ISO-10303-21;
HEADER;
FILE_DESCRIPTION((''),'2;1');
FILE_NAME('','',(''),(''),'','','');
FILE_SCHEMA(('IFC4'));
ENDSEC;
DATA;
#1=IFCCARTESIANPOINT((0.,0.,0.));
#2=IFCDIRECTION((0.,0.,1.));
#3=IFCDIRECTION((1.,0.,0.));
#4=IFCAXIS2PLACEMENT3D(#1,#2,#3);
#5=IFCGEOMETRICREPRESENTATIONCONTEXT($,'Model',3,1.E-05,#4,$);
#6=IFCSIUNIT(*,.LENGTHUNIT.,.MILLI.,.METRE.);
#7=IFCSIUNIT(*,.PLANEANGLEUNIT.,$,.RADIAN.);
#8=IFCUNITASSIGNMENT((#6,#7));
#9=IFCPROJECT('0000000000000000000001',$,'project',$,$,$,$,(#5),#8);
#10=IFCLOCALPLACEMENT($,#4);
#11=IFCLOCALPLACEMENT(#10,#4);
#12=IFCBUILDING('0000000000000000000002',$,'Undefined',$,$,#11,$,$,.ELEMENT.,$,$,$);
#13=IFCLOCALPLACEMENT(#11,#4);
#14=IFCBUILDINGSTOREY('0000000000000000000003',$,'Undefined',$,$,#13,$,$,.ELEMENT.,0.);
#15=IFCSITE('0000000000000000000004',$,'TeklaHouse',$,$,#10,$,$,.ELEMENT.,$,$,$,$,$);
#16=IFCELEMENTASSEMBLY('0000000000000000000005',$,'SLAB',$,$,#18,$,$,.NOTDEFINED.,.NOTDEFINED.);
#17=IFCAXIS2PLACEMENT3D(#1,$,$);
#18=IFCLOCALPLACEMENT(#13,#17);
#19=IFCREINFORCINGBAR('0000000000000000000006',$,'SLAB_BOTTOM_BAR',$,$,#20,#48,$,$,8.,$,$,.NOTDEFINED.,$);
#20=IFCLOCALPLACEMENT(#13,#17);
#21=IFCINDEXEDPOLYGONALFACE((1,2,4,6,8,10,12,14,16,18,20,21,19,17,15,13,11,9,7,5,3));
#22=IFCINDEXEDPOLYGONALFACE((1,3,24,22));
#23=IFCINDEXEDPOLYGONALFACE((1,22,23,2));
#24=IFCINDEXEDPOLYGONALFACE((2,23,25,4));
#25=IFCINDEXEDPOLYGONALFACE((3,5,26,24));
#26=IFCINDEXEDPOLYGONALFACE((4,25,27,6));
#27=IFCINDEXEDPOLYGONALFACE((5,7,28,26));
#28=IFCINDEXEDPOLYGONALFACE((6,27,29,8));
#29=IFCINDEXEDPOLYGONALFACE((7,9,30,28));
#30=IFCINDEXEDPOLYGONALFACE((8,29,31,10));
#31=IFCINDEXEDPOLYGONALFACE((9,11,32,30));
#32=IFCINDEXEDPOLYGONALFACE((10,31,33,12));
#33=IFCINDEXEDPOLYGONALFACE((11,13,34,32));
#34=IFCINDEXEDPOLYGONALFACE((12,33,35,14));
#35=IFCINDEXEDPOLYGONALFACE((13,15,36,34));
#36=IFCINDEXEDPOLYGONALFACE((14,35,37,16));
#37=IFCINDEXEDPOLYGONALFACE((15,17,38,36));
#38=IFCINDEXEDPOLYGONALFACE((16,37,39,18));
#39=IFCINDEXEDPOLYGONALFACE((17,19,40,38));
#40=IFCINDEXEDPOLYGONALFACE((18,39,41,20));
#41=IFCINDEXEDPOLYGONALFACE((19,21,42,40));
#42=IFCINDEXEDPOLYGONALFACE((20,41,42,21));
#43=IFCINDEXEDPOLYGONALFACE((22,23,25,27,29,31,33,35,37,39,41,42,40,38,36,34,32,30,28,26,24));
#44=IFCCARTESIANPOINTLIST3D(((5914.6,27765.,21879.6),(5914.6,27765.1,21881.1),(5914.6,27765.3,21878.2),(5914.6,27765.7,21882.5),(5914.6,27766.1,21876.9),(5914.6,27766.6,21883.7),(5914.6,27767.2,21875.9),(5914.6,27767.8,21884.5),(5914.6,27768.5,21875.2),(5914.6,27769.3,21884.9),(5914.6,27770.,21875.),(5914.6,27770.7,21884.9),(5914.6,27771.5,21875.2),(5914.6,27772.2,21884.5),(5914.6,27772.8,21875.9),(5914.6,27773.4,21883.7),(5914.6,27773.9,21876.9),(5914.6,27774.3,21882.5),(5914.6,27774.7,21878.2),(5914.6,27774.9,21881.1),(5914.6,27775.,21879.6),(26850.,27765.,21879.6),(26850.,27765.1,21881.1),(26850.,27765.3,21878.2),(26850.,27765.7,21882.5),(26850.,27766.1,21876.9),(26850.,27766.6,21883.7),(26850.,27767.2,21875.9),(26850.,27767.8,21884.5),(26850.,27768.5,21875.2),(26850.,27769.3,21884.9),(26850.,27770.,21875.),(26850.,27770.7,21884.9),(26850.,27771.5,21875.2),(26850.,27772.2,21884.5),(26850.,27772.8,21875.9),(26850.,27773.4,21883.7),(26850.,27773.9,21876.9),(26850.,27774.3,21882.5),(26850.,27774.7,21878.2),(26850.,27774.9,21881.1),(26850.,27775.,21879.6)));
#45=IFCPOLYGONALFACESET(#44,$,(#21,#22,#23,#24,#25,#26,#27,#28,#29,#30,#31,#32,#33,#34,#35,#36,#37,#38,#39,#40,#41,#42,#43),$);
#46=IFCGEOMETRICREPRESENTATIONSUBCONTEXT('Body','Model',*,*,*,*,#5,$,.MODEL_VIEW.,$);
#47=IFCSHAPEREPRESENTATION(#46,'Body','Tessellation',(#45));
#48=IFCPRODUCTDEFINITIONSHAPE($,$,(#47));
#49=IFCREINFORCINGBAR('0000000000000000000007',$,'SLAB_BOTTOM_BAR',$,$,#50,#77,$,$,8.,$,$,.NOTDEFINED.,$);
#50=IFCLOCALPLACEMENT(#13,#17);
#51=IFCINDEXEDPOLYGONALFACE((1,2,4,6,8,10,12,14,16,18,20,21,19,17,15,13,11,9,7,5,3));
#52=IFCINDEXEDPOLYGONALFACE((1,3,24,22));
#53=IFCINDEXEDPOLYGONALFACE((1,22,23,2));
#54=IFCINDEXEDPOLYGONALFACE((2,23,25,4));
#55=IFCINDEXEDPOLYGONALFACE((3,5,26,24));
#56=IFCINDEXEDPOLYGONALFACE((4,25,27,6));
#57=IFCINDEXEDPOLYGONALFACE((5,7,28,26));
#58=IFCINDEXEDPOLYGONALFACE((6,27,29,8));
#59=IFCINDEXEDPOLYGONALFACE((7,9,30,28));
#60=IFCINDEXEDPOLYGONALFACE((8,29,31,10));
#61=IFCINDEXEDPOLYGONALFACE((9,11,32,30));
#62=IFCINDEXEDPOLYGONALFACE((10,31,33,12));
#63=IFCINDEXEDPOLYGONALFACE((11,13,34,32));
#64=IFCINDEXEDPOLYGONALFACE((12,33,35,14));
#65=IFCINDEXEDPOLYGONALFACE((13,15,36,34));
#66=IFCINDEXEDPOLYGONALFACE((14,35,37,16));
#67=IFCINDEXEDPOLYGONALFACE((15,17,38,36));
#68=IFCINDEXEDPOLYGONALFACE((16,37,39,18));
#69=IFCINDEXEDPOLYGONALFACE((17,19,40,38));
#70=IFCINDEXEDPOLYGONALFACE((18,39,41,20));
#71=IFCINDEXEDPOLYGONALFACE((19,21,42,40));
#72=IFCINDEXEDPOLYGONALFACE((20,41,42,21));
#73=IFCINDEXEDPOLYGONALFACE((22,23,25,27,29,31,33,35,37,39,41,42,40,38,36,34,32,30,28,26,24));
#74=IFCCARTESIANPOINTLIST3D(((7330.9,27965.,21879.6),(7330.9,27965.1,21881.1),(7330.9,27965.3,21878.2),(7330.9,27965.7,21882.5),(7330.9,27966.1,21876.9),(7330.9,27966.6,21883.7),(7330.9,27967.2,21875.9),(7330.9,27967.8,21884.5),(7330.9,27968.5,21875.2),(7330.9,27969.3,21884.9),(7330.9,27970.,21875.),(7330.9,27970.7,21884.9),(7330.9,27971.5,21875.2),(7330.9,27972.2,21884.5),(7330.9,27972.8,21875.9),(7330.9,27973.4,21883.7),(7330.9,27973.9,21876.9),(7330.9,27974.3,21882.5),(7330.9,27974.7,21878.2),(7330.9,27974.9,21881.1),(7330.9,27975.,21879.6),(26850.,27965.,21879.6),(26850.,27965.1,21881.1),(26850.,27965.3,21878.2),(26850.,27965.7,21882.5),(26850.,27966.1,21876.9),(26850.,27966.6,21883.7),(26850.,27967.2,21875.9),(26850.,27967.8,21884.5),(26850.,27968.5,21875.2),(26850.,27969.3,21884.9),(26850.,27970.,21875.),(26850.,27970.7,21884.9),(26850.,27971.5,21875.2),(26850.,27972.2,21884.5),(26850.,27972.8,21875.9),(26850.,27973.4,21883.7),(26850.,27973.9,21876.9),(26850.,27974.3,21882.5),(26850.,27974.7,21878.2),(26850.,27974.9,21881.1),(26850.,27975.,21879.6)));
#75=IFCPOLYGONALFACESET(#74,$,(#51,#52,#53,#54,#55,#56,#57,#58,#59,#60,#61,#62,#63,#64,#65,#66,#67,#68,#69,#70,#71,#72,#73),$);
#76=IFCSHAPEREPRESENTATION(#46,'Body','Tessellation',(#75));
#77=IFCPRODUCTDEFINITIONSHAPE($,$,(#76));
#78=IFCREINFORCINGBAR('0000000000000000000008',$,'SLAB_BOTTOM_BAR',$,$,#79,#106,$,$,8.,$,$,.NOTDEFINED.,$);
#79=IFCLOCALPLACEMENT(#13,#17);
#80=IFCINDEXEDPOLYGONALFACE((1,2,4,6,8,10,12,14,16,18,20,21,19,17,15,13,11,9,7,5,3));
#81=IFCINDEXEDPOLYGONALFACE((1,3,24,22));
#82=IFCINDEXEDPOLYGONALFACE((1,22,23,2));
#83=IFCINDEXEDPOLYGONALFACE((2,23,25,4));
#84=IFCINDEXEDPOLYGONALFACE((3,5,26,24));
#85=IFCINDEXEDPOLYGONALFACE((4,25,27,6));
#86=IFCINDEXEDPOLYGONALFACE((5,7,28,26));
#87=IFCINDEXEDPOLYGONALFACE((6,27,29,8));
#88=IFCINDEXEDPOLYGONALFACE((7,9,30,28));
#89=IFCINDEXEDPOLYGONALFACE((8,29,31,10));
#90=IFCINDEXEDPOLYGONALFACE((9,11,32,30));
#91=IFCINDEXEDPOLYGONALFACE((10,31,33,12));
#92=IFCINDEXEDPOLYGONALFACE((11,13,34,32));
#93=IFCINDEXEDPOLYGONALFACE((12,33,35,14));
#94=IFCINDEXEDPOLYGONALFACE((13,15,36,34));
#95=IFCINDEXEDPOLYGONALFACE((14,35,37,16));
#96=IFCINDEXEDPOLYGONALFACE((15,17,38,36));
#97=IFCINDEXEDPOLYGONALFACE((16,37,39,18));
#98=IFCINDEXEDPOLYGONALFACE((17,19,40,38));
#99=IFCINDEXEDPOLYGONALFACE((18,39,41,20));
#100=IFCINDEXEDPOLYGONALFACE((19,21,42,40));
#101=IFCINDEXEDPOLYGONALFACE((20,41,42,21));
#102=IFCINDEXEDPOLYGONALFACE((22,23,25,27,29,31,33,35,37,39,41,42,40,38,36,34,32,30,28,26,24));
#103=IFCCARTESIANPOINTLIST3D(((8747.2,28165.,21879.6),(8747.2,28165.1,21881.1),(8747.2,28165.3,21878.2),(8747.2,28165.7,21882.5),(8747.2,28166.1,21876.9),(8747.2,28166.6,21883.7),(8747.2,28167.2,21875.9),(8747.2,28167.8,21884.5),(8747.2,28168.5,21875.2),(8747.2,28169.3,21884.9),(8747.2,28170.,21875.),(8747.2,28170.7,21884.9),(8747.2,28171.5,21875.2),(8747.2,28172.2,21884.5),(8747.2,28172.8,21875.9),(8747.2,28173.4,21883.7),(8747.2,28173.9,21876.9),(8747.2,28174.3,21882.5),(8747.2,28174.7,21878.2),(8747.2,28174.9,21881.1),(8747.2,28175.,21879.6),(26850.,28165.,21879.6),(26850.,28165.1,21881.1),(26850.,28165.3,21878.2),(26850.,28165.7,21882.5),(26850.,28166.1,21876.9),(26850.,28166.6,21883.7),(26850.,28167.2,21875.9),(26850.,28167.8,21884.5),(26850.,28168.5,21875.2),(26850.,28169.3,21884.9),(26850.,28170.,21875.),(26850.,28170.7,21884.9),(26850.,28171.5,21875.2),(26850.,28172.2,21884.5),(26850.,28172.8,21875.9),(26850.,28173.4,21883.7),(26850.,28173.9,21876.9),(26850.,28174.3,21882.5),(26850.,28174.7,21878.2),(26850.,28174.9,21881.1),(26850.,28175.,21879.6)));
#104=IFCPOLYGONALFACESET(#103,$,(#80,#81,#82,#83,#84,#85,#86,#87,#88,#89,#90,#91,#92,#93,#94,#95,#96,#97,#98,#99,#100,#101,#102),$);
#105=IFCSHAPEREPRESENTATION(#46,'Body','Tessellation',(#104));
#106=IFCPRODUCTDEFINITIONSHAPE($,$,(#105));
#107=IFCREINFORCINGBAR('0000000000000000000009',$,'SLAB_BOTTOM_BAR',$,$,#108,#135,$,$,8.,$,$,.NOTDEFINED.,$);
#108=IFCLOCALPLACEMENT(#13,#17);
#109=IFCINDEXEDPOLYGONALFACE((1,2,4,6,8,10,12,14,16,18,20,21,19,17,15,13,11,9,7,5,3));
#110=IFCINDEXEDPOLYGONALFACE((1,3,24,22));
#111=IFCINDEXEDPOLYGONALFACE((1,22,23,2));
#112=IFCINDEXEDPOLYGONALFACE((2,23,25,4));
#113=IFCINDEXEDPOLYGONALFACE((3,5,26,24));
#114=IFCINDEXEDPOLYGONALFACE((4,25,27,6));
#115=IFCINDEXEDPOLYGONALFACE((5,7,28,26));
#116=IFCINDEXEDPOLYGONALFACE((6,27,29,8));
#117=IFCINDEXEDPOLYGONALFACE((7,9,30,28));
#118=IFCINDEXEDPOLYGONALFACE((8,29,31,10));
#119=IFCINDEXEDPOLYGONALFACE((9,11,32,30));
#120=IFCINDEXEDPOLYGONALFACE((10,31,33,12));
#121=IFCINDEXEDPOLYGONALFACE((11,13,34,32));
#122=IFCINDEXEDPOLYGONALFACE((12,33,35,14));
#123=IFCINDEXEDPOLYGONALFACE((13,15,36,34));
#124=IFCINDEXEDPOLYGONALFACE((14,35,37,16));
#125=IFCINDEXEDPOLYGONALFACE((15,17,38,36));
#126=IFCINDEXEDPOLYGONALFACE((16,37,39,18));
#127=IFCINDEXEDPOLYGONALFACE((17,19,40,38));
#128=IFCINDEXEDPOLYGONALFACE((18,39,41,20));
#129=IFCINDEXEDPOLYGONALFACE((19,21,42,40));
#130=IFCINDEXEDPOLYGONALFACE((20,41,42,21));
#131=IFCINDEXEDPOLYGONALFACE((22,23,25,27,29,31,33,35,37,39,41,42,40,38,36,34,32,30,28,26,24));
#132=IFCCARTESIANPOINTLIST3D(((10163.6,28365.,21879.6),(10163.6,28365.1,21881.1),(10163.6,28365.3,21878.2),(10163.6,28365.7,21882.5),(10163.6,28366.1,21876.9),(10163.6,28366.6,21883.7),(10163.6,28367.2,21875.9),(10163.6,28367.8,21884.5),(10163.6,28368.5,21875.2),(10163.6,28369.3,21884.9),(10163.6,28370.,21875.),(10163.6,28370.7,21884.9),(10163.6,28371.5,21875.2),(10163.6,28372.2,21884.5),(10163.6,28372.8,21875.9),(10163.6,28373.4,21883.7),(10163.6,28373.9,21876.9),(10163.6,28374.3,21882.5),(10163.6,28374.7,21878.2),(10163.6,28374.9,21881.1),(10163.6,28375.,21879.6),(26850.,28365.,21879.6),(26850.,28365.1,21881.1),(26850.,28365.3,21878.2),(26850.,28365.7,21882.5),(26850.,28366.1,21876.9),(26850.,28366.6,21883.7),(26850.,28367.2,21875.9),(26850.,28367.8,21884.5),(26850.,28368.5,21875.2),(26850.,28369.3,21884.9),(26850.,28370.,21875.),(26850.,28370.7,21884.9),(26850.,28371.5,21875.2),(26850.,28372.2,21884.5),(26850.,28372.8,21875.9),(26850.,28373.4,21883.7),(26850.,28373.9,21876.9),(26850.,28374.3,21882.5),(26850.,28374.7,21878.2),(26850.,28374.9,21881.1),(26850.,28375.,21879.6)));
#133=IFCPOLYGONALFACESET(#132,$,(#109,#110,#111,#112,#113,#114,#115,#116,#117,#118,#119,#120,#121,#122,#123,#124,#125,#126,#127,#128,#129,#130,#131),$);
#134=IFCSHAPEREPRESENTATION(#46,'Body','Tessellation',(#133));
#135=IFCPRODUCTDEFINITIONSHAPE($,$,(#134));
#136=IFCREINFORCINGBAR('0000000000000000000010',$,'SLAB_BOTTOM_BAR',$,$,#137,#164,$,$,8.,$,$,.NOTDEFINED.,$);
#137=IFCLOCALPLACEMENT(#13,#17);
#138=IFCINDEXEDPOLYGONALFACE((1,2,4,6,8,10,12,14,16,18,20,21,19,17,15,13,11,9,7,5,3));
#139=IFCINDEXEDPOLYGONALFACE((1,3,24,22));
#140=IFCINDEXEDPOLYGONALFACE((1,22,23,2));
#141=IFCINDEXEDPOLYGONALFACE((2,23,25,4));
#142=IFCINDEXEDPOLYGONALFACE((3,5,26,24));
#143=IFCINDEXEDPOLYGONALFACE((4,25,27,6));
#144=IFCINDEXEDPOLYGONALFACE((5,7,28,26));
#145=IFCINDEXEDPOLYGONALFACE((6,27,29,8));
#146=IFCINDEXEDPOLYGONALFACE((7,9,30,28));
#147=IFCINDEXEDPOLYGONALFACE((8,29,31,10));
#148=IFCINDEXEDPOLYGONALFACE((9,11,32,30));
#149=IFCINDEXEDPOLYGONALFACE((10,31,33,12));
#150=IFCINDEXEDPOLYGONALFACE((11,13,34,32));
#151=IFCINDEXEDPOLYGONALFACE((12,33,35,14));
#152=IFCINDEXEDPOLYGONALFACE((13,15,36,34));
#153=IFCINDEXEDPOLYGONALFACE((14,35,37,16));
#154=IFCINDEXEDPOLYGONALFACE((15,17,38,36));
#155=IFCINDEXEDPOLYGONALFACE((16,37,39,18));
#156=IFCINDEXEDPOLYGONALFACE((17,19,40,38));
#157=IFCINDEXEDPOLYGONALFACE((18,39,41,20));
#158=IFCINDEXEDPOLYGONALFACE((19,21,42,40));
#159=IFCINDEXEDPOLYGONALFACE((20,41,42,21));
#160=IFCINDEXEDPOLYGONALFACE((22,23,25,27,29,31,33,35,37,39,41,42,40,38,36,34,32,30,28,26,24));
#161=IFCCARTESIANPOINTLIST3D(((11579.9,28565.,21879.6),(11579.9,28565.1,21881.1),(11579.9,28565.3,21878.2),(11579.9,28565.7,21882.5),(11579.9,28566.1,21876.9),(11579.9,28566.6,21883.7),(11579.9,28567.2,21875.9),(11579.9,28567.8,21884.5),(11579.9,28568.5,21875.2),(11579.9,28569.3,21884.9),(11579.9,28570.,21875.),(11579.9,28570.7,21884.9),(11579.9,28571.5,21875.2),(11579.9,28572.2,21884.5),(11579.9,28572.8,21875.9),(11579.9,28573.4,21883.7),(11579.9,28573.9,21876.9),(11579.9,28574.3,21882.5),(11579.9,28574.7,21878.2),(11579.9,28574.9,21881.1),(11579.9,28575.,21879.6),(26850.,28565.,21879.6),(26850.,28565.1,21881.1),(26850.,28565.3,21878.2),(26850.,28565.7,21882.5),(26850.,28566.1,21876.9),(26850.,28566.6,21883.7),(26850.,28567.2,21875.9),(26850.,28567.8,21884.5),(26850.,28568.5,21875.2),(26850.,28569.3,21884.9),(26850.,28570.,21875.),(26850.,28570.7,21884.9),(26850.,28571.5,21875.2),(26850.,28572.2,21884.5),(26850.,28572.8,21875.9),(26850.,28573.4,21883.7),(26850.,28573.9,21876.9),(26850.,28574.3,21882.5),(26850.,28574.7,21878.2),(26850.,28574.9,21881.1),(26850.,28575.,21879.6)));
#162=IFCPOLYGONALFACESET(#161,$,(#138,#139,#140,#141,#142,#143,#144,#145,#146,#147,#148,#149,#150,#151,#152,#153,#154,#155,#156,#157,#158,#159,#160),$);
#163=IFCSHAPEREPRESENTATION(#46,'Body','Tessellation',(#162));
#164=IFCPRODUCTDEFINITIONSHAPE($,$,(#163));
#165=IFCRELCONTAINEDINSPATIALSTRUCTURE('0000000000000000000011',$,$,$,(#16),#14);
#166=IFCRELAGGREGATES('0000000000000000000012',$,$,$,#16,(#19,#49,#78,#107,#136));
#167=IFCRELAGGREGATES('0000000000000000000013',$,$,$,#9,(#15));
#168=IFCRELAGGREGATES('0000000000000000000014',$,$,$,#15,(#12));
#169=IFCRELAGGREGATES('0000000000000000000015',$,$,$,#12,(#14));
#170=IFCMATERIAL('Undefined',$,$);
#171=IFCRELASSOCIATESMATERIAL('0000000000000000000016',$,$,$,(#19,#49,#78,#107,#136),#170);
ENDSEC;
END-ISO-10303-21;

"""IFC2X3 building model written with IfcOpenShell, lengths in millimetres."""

from ifc_helpers import new_model, entity, si_unit, frame, origin_with_axes, place, context, subcontext, project, spatial, source, transform, mapped, material, element, aggregate, save


model = new_model("IFC2X3")

# Units and contexts
model_context = context("Model", 3, precision=1e-05, world=origin_with_axes())
body_context = subcontext(model_context, "Body", "Model", "MODEL_VIEW")
ifc_project = project(units=[si_unit("LENGTHUNIT", "METRE", prefix="MILLI"), si_unit("PLANEANGLEUNIT", "RADIAN")], contexts=[model_context])

# Site, building, storey
site_placement = place(None, origin_with_axes())
site = spatial("IfcSite", under=ifc_project, at=site_placement, Name="TeklaHouse", CompositionType="ELEMENT")
building_placement = place(site_placement, origin_with_axes())
building = spatial("IfcBuilding", under=site, at=building_placement, Name="Undefined", CompositionType="ELEMENT")
storey_placement = place(building_placement, origin_with_axes())
storey = spatial("IfcBuildingStorey", under=building, at=storey_placement, Name="Undefined", CompositionType="ELEMENT", Elevation=0.0)

# Element assembly, reinforcing bars
assembly_1_placement = place(storey_placement, origin_with_axes())
assembly_1 = element("IfcElementAssembly", 1, at=assembly_1_placement, inside=storey, Name="SLAB", AssemblyPlace="NOTDEFINED", PredefinedType="NOTDEFINED")
ifc_material_1 = material(Name="Undefined")
shared_shape_1 = source(origin_with_axes(), body_context, "Body", "AdvancedSweptSolid", [
    entity("IfcSweptDiskSolid", entity("IfcTrimmedCurve", entity("IfcLine", entity("IfcCartesianPoint", [0.0, 0.0, 0.0]), entity("IfcVector", entity("IfcDirection", [1.0, 0.0, 0.0]), 1.0)), [entity("IfcParameterValue", 0.0)], [entity("IfcParameterValue", 20935.411553)], True, "PARAMETER"), 5.0, None, 0.0, 20935.4),
])
reinforcing_bar_1_placement = place(assembly_1_placement, frame((26850.0, 27770.0, 21880.0), z_axis=(0.0, 0.0, -1.0), x_axis=(-1.0, 0.0, 0.0)))
reinforcing_bar_1 = element("IfcReinforcingBar", 2, at=reinforcing_bar_1_placement, material=ifc_material_1, Name="SLAB_BOTTOM_BAR", BarRole="NOTDEFINED", NominalDiameter=8.0, context=body_context, shape_type="MappedRepresentation", body=[
    mapped(shared_shape_1, transform((0.0, 0.0, 0.0))),
])
shared_shape_2 = source(origin_with_axes(), body_context, "Body", "AdvancedSweptSolid", [
    entity("IfcSweptDiskSolid", entity("IfcTrimmedCurve", entity("IfcLine", entity("IfcCartesianPoint", [0.0, 0.0, 0.0]), entity("IfcVector", entity("IfcDirection", [1.0, 0.0, 0.0]), 1.0)), [entity("IfcParameterValue", 0.0)], [entity("IfcParameterValue", 19519.086817)], True, "PARAMETER"), 5.0, None, 0.0, 19519.1),
])
reinforcing_bar_2_placement = place(assembly_1_placement, frame((26850.0, 27970.0, 21880.0), z_axis=(0.0, 0.0, -1.0), x_axis=(-1.0, 0.0, 0.0)))
reinforcing_bar_2 = element("IfcReinforcingBar", 3, at=reinforcing_bar_2_placement, material=ifc_material_1, Name="SLAB_BOTTOM_BAR", BarRole="NOTDEFINED", NominalDiameter=8.0, context=body_context, shape_type="MappedRepresentation", body=[
    mapped(shared_shape_2, transform((0.0, 0.0, 0.0))),
])
shared_shape_3 = source(origin_with_axes(), body_context, "Body", "AdvancedSweptSolid", [
    entity("IfcSweptDiskSolid", entity("IfcTrimmedCurve", entity("IfcLine", entity("IfcCartesianPoint", [0.0, 0.0, 0.0]), entity("IfcVector", entity("IfcDirection", [1.0, 0.0, 0.0]), 1.0)), [entity("IfcParameterValue", 0.0)], [entity("IfcParameterValue", 18102.762081)], True, "PARAMETER"), 5.0, None, 0.0, 18102.8),
])
reinforcing_bar_3_placement = place(assembly_1_placement, frame((26850.0, 28170.0, 21880.0), z_axis=(0.0, 0.0, -1.0), x_axis=(-1.0, 0.0, 0.0)))
reinforcing_bar_3 = element("IfcReinforcingBar", 4, at=reinforcing_bar_3_placement, material=ifc_material_1, Name="SLAB_BOTTOM_BAR", BarRole="NOTDEFINED", NominalDiameter=8.0, context=body_context, shape_type="MappedRepresentation", body=[
    mapped(shared_shape_3, transform((0.0, 0.0, 0.0))),
])
shared_shape_4 = source(origin_with_axes(), body_context, "Body", "AdvancedSweptSolid", [
    entity("IfcSweptDiskSolid", entity("IfcTrimmedCurve", entity("IfcLine", entity("IfcCartesianPoint", [0.0, 0.0, 0.0]), entity("IfcVector", entity("IfcDirection", [1.0, 0.0, 0.0]), 1.0)), [entity("IfcParameterValue", 0.0)], [entity("IfcParameterValue", 16686.437345)], True, "PARAMETER"), 5.0, None, 0.0, 16686.4),
])
reinforcing_bar_4_placement = place(assembly_1_placement, frame((26850.0, 28370.0, 21880.0), z_axis=(0.0, 0.0, -1.0), x_axis=(-1.0, 0.0, 0.0)))
reinforcing_bar_4 = element("IfcReinforcingBar", 5, at=reinforcing_bar_4_placement, material=ifc_material_1, Name="SLAB_BOTTOM_BAR", BarRole="NOTDEFINED", NominalDiameter=8.0, context=body_context, shape_type="MappedRepresentation", body=[
    mapped(shared_shape_4, transform((0.0, 0.0, 0.0))),
])
shared_shape_5 = source(origin_with_axes(), body_context, "Body", "AdvancedSweptSolid", [
    entity("IfcSweptDiskSolid", entity("IfcTrimmedCurve", entity("IfcLine", entity("IfcCartesianPoint", [0.0, 0.0, 0.0]), entity("IfcVector", entity("IfcDirection", [1.0, 0.0, 0.0]), 1.0)), [entity("IfcParameterValue", 0.0)], [entity("IfcParameterValue", 15270.112609)], True, "PARAMETER"), 5.0, None, 0.0, 15270.1),
])
reinforcing_bar_5_placement = place(assembly_1_placement, frame((26850.0, 28570.0, 21880.0), z_axis=(0.0, 0.0, -1.0), x_axis=(-1.0, 0.0, 0.0)))
reinforcing_bar_5 = element("IfcReinforcingBar", 6, at=reinforcing_bar_5_placement, material=ifc_material_1, Name="SLAB_BOTTOM_BAR", BarRole="NOTDEFINED", NominalDiameter=8.0, context=body_context, shape_type="MappedRepresentation", body=[
    mapped(shared_shape_5, transform((0.0, 0.0, 0.0))),
])
aggregate(assembly_1, [reinforcing_bar_1, reinforcing_bar_2, reinforcing_bar_3, reinforcing_bar_4, reinforcing_bar_5])

save(model, "model.ifc")
